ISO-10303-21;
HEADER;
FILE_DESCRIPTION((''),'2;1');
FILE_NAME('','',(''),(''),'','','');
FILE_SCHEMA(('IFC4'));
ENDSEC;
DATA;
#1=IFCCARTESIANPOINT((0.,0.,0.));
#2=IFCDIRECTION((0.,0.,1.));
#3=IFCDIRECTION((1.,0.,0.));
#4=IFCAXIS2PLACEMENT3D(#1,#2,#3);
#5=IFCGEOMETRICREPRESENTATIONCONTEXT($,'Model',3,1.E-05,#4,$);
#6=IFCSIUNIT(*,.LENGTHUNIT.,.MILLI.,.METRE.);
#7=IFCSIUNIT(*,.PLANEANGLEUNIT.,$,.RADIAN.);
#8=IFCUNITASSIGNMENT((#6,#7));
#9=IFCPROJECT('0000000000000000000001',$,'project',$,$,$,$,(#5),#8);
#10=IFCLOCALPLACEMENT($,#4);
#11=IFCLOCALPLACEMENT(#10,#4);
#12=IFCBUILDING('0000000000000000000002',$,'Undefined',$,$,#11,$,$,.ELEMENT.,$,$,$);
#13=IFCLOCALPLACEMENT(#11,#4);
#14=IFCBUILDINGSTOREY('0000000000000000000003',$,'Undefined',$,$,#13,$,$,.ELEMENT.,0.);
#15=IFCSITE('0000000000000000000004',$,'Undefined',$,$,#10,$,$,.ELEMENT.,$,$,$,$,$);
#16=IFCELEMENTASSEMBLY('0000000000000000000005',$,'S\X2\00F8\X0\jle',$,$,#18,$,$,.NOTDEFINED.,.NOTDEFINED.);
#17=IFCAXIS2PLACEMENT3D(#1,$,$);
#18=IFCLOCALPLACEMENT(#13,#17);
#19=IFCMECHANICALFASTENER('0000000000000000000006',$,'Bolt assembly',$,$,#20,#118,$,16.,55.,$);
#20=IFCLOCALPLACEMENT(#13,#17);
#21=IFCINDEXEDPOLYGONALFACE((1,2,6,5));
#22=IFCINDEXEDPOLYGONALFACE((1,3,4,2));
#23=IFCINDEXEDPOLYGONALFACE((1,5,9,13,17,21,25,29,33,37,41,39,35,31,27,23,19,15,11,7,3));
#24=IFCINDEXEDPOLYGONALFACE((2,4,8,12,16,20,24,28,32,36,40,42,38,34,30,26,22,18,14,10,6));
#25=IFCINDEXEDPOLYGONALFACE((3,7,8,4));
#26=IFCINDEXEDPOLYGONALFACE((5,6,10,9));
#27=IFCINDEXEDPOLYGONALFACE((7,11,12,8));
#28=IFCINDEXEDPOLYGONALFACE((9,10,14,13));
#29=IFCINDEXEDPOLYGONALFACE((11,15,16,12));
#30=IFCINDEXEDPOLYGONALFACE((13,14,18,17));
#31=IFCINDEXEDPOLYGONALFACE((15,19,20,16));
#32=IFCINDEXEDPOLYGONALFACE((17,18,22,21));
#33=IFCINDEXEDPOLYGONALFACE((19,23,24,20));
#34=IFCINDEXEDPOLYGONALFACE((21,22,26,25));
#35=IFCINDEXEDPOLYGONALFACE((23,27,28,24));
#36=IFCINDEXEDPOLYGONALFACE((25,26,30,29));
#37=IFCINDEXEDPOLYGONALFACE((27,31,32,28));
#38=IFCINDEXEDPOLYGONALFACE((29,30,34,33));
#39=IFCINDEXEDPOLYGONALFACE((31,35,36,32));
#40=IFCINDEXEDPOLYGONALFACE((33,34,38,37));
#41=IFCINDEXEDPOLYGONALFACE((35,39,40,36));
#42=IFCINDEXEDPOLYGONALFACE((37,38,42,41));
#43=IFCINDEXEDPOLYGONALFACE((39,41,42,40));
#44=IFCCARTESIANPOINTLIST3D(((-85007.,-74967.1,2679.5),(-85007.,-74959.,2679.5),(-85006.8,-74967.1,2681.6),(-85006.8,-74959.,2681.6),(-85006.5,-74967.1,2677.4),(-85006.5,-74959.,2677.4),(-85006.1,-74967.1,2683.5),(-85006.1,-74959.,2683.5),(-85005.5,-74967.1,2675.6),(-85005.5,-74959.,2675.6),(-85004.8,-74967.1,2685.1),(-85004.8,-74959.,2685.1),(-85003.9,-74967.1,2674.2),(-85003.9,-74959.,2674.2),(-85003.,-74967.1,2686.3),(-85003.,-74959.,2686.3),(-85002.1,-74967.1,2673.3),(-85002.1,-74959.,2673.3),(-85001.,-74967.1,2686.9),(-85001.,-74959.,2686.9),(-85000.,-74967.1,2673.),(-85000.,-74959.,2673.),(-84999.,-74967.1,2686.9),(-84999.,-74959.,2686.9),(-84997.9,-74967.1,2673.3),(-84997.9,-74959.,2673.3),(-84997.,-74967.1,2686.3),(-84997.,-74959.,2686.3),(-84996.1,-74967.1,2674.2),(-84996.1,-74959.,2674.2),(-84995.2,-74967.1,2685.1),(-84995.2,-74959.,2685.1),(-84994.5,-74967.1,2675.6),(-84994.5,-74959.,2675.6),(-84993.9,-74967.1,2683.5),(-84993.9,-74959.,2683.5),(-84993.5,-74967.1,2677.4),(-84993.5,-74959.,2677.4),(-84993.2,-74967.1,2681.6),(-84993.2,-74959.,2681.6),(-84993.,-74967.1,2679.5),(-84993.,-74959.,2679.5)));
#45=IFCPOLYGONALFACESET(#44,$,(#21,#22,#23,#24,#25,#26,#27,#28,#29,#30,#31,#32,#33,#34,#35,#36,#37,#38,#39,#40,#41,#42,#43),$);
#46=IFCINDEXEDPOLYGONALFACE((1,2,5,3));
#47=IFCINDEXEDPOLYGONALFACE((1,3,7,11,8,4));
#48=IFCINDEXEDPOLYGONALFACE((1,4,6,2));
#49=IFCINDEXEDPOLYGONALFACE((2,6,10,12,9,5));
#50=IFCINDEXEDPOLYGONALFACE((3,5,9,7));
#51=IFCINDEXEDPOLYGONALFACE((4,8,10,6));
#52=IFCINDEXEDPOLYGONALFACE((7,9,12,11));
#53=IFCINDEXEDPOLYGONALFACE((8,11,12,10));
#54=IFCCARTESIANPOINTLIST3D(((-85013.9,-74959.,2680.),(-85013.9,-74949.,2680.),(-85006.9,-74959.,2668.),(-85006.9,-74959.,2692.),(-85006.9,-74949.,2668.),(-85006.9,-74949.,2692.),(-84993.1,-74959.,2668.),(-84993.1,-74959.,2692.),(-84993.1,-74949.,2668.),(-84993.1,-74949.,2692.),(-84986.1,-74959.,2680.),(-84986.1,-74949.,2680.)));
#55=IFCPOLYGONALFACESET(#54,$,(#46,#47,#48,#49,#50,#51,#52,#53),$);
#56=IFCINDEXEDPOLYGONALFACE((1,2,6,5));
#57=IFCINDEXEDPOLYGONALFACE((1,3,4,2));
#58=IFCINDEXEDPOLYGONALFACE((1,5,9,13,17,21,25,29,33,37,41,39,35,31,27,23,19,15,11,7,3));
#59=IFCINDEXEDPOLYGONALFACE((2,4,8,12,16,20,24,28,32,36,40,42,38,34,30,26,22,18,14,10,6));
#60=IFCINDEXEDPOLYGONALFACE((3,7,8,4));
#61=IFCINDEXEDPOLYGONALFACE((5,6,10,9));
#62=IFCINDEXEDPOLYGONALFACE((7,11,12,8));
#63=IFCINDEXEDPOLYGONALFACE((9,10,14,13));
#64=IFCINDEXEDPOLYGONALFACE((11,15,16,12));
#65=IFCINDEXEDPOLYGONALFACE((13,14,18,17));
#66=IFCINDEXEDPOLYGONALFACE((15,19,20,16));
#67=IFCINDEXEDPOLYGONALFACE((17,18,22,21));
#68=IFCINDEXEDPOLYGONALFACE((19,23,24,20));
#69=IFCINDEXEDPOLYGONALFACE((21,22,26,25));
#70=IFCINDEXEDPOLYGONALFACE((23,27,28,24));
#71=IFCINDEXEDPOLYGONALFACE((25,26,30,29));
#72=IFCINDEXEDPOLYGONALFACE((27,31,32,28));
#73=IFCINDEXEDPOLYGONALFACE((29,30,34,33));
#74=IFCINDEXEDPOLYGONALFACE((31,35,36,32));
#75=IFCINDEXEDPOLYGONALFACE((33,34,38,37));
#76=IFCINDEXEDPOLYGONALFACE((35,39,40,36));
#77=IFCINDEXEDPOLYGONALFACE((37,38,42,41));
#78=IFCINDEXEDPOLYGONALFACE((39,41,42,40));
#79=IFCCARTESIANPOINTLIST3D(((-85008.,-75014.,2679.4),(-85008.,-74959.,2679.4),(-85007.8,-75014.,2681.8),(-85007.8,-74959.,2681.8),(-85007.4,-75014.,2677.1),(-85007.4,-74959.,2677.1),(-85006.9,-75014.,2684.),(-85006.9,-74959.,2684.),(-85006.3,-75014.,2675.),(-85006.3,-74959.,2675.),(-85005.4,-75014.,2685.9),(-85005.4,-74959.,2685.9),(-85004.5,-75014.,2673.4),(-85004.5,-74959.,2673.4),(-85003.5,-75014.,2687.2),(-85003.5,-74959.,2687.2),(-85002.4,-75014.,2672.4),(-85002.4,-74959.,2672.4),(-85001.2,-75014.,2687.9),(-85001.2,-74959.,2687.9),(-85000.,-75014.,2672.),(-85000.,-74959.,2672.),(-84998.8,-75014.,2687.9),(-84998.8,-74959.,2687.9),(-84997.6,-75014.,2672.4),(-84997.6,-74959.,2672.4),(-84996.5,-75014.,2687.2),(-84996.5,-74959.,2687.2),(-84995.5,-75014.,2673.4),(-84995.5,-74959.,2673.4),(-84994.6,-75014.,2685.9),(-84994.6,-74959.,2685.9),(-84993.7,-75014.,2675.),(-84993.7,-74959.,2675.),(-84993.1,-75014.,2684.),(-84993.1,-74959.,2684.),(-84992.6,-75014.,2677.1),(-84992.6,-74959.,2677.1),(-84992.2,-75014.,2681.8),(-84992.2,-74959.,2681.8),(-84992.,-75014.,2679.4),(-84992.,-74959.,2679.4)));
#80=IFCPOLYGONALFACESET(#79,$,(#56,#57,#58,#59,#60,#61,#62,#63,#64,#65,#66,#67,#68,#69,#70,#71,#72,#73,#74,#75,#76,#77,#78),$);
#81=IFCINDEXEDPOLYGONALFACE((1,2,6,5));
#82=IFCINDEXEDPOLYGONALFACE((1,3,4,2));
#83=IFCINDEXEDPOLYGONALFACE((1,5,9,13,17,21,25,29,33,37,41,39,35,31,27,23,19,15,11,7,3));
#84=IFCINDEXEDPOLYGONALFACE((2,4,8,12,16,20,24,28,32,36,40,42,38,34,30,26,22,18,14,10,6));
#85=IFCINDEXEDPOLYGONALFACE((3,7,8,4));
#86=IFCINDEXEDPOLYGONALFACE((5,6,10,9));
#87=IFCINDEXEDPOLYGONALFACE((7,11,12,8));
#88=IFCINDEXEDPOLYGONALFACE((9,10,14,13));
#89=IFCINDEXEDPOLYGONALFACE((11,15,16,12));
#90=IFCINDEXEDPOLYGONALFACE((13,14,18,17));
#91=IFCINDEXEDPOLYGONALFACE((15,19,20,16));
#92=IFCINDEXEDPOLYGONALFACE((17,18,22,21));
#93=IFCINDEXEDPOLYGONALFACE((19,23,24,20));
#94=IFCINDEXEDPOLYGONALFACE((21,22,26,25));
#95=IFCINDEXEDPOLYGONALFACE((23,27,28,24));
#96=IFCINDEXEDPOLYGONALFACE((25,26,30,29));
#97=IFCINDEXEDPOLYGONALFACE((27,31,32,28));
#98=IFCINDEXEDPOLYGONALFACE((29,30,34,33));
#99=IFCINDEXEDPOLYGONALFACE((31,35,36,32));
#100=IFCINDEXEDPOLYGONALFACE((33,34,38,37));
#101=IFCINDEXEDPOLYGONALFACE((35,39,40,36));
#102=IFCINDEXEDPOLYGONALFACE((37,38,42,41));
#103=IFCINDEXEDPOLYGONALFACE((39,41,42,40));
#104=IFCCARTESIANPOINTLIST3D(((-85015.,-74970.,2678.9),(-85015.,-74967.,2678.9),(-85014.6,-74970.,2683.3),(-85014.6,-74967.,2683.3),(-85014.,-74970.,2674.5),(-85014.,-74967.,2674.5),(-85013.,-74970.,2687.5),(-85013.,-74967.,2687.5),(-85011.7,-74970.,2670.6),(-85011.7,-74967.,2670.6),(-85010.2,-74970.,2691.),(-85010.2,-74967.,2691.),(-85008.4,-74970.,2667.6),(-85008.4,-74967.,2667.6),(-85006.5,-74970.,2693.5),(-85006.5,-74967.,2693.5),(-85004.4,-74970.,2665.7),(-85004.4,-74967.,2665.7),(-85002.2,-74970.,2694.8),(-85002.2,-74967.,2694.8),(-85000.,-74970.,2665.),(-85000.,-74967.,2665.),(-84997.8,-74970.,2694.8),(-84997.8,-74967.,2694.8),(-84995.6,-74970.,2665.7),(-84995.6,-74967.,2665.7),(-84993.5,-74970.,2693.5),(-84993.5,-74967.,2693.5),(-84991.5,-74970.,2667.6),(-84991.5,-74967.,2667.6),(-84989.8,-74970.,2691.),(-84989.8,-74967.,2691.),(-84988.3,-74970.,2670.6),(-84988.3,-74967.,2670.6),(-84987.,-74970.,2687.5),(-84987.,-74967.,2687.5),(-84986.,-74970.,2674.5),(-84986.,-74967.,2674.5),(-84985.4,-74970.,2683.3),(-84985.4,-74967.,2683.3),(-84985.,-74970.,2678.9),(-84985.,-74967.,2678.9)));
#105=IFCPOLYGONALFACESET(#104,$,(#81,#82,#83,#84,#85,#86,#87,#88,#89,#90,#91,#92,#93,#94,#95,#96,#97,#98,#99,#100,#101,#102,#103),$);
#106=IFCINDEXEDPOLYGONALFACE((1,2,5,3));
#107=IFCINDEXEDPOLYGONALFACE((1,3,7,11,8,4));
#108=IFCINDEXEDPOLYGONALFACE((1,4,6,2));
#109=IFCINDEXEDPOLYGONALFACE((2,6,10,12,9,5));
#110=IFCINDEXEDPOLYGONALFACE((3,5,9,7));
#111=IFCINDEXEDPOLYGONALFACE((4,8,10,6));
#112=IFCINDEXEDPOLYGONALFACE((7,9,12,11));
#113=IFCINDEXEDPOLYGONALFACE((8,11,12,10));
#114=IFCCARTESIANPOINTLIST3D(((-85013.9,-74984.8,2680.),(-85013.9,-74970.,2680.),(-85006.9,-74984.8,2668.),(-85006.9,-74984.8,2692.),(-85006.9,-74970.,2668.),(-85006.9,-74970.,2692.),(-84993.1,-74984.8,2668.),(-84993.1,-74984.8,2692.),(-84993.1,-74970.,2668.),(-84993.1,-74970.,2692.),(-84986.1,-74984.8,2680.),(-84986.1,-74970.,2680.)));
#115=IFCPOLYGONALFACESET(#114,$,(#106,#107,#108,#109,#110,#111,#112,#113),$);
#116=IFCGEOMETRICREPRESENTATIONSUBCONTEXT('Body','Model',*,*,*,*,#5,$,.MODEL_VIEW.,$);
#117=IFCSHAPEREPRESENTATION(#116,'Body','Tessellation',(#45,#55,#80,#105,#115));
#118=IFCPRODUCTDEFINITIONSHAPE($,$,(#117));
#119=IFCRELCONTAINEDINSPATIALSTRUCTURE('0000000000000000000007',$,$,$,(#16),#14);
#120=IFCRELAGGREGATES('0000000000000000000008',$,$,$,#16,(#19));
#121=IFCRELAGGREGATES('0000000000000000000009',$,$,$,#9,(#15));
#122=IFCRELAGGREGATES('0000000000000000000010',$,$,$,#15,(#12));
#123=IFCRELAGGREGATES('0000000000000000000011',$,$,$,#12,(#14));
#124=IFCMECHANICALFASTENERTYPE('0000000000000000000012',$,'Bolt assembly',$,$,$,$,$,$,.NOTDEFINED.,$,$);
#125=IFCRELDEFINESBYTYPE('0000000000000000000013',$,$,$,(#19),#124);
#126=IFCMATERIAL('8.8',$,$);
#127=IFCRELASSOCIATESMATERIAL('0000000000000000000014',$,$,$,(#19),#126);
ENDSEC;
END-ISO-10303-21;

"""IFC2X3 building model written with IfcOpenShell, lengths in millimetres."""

from ifc_helpers import new_model, si_unit, frame, origin_with_axes, origin_2d_with_axis, place, context, subcontext, project, spatial, polyline, circle, outline, extrude, source, transform, mapped, material, type_object, element, aggregate, save


model = new_model("IFC2X3")

# Units and contexts
model_context = context("Model", 3, precision=1e-05, world=origin_with_axes())
body_context = subcontext(model_context, "Body", "Model", "MODEL_VIEW")
ifc_project = project(units=[si_unit("LENGTHUNIT", "METRE", prefix="MILLI"), si_unit("PLANEANGLEUNIT", "RADIAN")], contexts=[model_context])

# Site, building, storey
site_placement = place(None, origin_with_axes())
site = spatial("IfcSite", under=ifc_project, at=site_placement, Name="Undefined", CompositionType="ELEMENT")
building_placement = place(site_placement, origin_with_axes())
building = spatial("IfcBuilding", under=site, at=building_placement, Name="Undefined", CompositionType="ELEMENT")
storey_placement = place(building_placement, origin_with_axes())
storey = spatial("IfcBuildingStorey", under=building, at=storey_placement, Name="Undefined", CompositionType="ELEMENT", Elevation=0.0)

# Element assembly
assembly_1_placement = place(storey_placement, origin_with_axes())
assembly_1 = element("IfcElementAssembly", 1, at=assembly_1_placement, inside=storey, Name="Søjle", AssemblyPlace="NOTDEFINED", PredefinedType="NOTDEFINED")

# Mechanical fastener
ifc_material_1 = material(Name="8.8")
mechanical_fastener_type = type_object("IfcMechanicalFastenerType", Name="Bolt assembly")
shared_shape_1 = source(origin_with_axes(), body_context, "Body", "SweptSolid", [
    extrude(circle(Radius=7.0, at=origin_2d_with_axis()), frame((0.0, 0.0, 0.0), z_axis=(0.0, 1.0, 0.0), x_axis=(1.0, 0.0, 0.0)), (0.0, 0.0, 1.0), 8.1),
    extrude(outline(polyline([(12.0, -6.9), (12.0, 6.9), (0.0, 13.9), (-12.0, 6.9), (-12.0, -6.9), (0.0, -13.9), (12.0, -6.9)])), frame((0.0, -10.0, 0.0), z_axis=(0.0, 1.0, 0.0), x_axis=(1.0, 0.0, 0.0)), (0.0, 0.0, 1.0), 10.0),
    extrude(circle(Radius=8.0, at=origin_2d_with_axis()), frame((0.0, 0.0, 0.0), z_axis=(0.0, 1.0, 0.0), x_axis=(1.0, 0.0, 0.0)), (0.0, 0.0, 1.0), 55.0),
    extrude(circle(Radius=15.0, at=origin_2d_with_axis()), frame((0.0, 8.0, 0.0), z_axis=(0.0, 1.0, 0.0), x_axis=(1.0, 0.0, 0.0)), (0.0, 0.0, 1.0), 3.0),
    extrude(outline(polyline([(12.0, -6.9), (12.0, 6.9), (0.0, 13.9), (-12.0, 6.9), (-12.0, -6.9), (0.0, -13.9), (12.0, -6.9)])), frame((0.0, 11.0, 0.0), z_axis=(0.0, 1.0, 0.0), x_axis=(1.0, 0.0, 0.0)), (0.0, 0.0, 1.0), 14.8),
])
mechanical_fastener_1_placement = place(assembly_1_placement, frame((-85000.0, -74959.0, 2680.0), z_axis=(-1.0, 0.0, 0.0), x_axis=(0.0, 0.0, -1.0)))
mechanical_fastener_1 = element("IfcMechanicalFastener", 2, at=mechanical_fastener_1_placement, type_object=mechanical_fastener_type, material=ifc_material_1, Name="Bolt assembly", NominalDiameter=16.0, NominalLength=55.0, context=body_context, shape_type="MappedRepresentation", body=[
    mapped(shared_shape_1, transform((0.0, 0.0, 0.0))),
])
aggregate(assembly_1, [mechanical_fastener_1])

save(model, "model.ifc")
